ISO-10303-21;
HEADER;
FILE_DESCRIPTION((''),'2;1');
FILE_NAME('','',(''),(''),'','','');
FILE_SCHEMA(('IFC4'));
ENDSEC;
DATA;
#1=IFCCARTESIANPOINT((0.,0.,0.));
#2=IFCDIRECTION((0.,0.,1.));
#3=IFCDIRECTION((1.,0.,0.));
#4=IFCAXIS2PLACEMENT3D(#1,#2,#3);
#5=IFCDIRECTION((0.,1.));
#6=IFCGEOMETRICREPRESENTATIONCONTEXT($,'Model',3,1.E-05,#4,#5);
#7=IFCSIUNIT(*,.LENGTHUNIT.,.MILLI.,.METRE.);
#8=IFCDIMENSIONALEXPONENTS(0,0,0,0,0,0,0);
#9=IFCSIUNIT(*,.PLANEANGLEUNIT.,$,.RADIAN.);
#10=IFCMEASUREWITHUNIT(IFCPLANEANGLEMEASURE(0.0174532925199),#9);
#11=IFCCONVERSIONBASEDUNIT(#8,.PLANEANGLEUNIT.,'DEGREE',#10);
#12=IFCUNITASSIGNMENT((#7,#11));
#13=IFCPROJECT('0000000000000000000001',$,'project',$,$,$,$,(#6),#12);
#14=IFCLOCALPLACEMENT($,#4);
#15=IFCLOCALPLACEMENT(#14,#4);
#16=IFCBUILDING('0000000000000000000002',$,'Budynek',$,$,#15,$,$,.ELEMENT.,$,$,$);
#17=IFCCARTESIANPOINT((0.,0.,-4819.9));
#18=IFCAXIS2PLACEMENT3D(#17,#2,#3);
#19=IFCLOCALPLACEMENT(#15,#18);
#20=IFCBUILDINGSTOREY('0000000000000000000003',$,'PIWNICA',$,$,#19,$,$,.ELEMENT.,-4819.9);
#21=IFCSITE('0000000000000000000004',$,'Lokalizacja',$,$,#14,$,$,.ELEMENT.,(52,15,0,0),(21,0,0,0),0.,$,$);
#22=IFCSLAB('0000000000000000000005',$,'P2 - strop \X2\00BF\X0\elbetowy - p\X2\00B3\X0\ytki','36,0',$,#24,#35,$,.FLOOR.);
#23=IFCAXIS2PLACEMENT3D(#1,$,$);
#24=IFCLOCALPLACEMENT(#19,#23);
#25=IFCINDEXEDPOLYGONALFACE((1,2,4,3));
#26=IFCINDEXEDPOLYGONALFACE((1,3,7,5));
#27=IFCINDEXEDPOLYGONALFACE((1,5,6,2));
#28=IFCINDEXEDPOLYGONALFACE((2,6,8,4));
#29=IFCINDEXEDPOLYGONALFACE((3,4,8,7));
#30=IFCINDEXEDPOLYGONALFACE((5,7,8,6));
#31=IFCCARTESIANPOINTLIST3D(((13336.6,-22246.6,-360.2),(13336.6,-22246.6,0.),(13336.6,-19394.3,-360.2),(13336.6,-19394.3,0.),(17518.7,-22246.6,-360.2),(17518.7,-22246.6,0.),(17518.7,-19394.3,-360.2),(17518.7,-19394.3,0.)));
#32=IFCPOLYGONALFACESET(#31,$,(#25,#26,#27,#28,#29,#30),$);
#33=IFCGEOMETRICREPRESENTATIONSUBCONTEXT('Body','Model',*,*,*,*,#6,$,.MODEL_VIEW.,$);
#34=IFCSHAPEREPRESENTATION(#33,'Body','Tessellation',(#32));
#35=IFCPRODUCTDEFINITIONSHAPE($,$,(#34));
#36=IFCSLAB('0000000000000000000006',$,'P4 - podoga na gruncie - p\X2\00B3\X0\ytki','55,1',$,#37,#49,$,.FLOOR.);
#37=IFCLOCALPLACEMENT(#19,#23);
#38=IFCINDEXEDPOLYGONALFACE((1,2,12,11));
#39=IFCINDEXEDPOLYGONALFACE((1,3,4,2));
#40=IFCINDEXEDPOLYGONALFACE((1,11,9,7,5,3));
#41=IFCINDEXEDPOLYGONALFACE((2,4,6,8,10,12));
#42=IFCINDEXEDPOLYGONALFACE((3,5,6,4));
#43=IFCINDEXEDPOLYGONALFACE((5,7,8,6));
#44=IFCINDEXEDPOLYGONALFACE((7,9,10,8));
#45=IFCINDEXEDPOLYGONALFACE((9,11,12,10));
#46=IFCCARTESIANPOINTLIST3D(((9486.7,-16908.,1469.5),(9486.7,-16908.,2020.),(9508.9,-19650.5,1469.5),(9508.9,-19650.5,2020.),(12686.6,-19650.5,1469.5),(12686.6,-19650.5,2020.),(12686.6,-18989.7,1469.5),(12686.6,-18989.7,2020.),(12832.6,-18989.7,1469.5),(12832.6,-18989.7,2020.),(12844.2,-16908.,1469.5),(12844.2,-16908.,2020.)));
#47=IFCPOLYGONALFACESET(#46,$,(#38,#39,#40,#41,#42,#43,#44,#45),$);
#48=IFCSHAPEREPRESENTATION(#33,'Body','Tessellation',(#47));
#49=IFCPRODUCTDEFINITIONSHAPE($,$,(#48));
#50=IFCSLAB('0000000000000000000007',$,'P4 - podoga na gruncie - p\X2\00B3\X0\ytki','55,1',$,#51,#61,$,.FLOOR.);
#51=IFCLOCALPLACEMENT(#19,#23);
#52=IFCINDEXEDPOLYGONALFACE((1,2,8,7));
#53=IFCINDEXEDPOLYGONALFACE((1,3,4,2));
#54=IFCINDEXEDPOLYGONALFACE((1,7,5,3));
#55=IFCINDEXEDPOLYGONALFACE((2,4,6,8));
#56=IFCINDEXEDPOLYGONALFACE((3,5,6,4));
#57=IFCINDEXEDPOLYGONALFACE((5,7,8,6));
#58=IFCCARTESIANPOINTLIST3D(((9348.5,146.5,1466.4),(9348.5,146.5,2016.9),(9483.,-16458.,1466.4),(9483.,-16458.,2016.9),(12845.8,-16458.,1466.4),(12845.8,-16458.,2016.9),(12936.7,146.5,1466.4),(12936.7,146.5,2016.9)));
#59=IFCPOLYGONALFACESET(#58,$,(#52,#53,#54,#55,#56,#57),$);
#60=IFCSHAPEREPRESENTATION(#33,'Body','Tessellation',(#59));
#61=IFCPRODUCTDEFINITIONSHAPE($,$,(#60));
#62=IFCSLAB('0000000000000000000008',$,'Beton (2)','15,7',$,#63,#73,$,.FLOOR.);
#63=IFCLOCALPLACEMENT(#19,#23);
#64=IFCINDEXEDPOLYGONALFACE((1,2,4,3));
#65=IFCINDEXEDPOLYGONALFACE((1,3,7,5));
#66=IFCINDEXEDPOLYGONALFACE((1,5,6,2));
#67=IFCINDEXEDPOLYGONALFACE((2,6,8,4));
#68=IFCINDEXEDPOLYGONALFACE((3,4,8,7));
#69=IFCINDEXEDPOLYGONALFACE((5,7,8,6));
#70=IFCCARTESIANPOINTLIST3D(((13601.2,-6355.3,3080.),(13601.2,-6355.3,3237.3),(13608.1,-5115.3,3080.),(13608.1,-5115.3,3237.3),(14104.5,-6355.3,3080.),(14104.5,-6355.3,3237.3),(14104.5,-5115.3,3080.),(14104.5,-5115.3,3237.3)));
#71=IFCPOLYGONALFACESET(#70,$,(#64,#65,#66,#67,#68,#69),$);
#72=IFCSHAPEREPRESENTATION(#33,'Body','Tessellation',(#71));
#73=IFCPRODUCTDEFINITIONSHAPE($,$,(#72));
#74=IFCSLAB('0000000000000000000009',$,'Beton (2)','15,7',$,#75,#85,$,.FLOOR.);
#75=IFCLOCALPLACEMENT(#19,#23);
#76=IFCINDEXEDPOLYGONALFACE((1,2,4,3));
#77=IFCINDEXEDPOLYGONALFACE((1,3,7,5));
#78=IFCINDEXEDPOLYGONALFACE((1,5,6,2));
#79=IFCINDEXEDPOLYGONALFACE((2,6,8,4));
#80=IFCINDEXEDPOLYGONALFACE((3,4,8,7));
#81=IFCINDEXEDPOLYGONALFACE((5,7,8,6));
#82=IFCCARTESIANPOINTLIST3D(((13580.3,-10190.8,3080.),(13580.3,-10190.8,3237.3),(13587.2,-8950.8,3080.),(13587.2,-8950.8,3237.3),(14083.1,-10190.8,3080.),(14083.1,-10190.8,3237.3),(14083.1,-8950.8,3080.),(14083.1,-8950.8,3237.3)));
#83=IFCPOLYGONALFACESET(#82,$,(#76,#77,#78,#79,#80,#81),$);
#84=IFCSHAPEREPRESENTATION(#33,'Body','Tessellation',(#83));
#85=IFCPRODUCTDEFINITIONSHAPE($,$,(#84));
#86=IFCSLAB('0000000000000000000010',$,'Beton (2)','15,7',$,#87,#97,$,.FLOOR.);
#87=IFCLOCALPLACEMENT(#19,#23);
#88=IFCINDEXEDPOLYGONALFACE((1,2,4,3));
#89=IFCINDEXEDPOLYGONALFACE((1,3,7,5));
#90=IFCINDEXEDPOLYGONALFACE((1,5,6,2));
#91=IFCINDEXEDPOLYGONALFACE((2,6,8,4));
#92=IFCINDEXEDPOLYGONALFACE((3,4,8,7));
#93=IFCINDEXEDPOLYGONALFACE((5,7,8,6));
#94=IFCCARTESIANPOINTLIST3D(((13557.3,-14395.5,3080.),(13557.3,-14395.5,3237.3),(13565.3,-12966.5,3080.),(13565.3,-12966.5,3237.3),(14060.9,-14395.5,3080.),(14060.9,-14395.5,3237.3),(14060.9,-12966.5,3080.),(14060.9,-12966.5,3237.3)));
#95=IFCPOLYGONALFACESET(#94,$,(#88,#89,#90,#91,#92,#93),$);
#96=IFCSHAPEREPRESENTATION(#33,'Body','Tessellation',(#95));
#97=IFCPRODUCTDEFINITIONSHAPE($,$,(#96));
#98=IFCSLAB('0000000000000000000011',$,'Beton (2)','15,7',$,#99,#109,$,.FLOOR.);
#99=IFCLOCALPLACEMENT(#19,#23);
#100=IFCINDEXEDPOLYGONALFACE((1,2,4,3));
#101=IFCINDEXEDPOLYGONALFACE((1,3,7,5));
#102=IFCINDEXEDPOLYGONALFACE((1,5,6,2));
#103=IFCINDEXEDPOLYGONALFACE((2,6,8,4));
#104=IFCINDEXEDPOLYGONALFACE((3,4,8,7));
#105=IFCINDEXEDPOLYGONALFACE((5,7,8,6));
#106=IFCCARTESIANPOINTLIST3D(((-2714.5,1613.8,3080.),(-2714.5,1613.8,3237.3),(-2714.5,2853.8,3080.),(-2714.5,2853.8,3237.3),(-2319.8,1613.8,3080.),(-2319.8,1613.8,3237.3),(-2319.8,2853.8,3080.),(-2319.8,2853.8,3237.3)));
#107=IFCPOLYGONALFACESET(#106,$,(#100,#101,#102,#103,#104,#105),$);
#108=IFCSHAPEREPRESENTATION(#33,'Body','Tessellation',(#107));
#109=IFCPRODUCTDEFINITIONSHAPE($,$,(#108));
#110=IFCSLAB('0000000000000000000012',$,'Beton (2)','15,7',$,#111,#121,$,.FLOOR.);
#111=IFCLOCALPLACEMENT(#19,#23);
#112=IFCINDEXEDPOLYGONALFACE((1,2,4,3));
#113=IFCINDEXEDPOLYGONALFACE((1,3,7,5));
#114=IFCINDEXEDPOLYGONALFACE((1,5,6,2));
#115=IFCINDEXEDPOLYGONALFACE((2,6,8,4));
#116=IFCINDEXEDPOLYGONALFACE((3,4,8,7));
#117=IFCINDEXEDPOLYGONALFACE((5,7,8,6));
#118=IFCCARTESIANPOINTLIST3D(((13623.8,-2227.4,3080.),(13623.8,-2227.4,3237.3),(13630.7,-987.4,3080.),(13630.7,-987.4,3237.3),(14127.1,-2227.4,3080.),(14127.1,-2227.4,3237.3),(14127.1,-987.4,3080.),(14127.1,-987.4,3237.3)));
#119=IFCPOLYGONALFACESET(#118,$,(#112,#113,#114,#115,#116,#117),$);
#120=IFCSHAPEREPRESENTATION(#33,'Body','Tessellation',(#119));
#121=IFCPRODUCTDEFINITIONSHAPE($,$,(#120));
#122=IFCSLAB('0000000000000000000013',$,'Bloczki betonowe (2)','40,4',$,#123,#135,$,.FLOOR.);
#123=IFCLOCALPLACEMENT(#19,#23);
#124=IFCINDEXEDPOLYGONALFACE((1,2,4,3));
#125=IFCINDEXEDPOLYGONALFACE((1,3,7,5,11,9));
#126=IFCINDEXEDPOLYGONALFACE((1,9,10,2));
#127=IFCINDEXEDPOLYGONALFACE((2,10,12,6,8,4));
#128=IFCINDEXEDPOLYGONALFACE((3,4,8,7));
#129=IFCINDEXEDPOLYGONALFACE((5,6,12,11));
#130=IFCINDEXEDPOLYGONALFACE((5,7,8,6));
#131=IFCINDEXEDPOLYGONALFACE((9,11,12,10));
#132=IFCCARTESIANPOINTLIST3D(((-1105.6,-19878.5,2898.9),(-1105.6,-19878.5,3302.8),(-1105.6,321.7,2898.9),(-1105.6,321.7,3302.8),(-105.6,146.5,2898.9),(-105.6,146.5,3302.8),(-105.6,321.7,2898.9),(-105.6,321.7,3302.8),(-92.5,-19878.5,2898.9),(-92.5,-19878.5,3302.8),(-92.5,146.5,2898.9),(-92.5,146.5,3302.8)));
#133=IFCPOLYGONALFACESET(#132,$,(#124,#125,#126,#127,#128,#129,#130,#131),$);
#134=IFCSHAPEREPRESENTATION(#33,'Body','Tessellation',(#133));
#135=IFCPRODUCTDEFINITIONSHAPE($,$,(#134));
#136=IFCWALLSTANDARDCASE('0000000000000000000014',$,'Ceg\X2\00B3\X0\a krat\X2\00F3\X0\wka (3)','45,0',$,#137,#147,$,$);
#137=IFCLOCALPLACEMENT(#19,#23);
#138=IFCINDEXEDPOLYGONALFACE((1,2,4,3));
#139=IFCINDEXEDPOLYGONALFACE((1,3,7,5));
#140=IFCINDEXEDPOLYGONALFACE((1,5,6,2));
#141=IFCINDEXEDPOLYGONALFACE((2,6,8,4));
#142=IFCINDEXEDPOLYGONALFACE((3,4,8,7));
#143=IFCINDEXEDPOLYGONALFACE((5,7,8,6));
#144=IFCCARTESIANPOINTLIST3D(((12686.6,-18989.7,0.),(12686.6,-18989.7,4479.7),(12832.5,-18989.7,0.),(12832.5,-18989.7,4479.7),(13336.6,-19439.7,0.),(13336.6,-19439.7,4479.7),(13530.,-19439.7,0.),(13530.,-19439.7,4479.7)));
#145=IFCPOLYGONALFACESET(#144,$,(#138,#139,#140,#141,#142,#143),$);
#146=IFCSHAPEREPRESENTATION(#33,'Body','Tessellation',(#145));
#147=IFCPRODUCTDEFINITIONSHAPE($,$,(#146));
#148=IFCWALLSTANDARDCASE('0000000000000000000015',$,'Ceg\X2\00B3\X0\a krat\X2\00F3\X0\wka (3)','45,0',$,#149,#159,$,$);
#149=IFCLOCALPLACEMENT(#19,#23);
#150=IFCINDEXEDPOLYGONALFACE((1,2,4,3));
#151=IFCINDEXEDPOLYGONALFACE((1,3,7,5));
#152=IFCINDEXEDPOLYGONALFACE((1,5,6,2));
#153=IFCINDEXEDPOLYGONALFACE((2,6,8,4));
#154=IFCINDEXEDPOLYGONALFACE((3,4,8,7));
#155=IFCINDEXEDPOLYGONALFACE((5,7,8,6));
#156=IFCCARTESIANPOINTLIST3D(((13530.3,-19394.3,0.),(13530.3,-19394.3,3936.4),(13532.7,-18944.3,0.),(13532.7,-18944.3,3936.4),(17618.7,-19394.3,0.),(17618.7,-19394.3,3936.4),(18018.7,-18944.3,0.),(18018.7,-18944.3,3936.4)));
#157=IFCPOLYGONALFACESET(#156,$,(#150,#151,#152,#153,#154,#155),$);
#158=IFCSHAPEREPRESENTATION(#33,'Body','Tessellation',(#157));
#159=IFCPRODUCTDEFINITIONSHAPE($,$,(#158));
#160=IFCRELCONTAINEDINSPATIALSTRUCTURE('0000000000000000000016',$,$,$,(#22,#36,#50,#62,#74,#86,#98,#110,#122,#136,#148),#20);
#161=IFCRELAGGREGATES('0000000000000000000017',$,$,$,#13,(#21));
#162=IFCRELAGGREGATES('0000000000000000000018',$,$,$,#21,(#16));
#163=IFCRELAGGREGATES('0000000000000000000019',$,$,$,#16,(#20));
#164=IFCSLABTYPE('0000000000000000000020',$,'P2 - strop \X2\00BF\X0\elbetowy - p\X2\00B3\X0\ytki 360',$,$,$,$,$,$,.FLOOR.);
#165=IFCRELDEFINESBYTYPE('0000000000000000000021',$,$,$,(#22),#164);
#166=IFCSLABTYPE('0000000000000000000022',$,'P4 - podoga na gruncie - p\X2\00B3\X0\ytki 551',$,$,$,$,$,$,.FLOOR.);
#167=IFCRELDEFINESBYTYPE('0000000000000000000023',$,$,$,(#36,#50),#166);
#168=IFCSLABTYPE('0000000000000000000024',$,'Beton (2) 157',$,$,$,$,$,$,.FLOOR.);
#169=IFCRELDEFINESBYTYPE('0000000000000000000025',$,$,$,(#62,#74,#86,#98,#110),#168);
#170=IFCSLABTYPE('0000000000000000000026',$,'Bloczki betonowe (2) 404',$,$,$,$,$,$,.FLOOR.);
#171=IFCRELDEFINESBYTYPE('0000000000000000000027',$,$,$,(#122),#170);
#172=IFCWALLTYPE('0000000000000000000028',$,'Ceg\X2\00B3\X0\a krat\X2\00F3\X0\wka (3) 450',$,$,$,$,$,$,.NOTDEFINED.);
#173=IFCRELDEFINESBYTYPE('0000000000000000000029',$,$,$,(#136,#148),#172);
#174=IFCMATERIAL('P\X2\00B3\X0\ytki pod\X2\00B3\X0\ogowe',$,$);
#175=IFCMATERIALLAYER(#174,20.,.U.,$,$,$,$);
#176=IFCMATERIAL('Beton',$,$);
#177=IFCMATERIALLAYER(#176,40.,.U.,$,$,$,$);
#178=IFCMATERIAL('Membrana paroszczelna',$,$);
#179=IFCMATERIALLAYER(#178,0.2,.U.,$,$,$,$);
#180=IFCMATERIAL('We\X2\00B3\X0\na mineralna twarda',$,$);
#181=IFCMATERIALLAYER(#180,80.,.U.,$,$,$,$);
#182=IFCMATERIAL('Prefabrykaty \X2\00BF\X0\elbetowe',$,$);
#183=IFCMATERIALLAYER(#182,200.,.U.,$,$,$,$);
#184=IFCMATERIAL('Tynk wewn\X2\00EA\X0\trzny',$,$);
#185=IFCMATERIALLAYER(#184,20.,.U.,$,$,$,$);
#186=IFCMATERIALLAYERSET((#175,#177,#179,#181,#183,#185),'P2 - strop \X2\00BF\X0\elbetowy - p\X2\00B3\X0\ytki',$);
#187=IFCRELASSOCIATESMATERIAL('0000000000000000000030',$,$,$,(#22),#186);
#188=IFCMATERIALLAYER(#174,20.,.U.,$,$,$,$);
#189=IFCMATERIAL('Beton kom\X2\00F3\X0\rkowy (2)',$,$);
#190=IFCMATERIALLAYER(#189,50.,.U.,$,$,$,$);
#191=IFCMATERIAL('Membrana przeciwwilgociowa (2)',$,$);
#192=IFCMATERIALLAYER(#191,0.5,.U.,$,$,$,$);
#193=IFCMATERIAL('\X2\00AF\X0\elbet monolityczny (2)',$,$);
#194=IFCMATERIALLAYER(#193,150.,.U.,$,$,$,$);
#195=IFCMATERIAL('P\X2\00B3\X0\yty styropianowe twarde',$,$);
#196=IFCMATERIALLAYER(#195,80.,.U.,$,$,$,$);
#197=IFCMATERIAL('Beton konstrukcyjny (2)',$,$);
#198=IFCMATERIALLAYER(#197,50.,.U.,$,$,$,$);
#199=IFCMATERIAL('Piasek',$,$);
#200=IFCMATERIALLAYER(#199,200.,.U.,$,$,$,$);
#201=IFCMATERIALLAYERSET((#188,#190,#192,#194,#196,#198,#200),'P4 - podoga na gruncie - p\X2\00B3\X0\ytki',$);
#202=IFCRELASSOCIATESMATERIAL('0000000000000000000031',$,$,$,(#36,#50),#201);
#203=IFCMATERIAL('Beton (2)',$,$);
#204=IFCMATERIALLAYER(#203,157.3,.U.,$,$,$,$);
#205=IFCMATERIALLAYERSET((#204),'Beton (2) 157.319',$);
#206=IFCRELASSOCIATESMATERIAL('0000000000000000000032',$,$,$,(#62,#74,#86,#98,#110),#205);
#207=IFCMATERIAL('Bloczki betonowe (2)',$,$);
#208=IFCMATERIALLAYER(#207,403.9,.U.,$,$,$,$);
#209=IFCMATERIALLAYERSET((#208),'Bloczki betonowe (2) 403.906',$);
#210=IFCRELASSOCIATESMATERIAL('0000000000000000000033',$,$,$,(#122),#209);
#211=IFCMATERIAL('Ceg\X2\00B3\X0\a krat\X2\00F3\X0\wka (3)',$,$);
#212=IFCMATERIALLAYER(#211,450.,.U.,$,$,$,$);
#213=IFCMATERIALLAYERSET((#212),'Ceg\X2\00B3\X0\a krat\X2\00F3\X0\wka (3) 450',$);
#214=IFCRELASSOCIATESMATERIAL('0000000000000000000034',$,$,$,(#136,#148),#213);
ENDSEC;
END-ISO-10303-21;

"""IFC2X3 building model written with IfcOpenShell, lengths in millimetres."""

from ifc_helpers import new_model, entity, si_unit, converted_unit, direction, frame, origin_with_axes, place, context, subcontext, project, spatial, polyline, outline, extrude, material, layer, layer_set, layer_usage, type_object, element, save


model = new_model("IFC2X3")

# Units and contexts
model_context = context("Model", 3, precision=1e-05, world=origin_with_axes(), true_north=direction((0.0, 1.0)))
body_context = subcontext(model_context, "Body", "Model", "MODEL_VIEW")
ifc_project = project(units=[si_unit("LENGTHUNIT", "METRE", prefix="MILLI"), converted_unit("PLANEANGLEUNIT", "DEGREE", entity("IfcPlaneAngleMeasure", 0.0174532925199), si_unit("PLANEANGLEUNIT", "RADIAN"), dimensions=[0, 0, 0, 0, 0, 0, 0])], contexts=[model_context])

# Site, building, storey
site_placement = place(None, origin_with_axes())
site = spatial("IfcSite", under=ifc_project, at=site_placement, Name="Lokalizacja", CompositionType="ELEMENT", RefLatitude=(52, 15, 0, 0), RefLongitude=(21, 0, 0, 0), RefElevation=0.0)
building_placement = place(site_placement, origin_with_axes())
building = spatial("IfcBuilding", under=site, at=building_placement, Name="Budynek", CompositionType="ELEMENT")
storey_placement = place(building_placement, frame((0.0, 0.0, -4819.9), z_axis=(0.0, 0.0, 1.0), x_axis=(1.0, 0.0, 0.0)))
storey = spatial("IfcBuildingStorey", under=building, at=storey_placement, Name="PIWNICA", CompositionType="ELEMENT", Elevation=-4819.9)

# Slabs
ifc_material_1 = material(Name="P³ytki pod³ogowe")
ifc_layer_1 = layer(ifc_material_1, 20.0, ventilated="UNKNOWN")
ifc_material_2 = material(Name="Beton")
ifc_layer_2 = layer(ifc_material_2, 40.0, ventilated="UNKNOWN")
ifc_material_3 = material(Name="Membrana paroszczelna")
ifc_layer_3 = layer(ifc_material_3, 0.2, ventilated="UNKNOWN")
ifc_material_4 = material(Name="We³na mineralna twarda")
ifc_layer_4 = layer(ifc_material_4, 80.0, ventilated="UNKNOWN")
ifc_material_5 = material(Name="Prefabrykaty ¿elbetowe")
ifc_layer_5 = layer(ifc_material_5, 200.0, ventilated="UNKNOWN")
ifc_material_6 = material(Name="Tynk wewnêtrzny")
ifc_layer_6 = layer(ifc_material_6, 20.0, ventilated="UNKNOWN")
ifc_layer_set_1 = layer_set([ifc_layer_1, ifc_layer_2, ifc_layer_3, ifc_layer_4, ifc_layer_5, ifc_layer_6], Name="P2 - strop ¿elbetowy - p³ytki")
ifc_layer_usage_1 = layer_usage(ifc_layer_set_1, "AXIS3", "NEGATIVE", 360.2)
slab_type_1 = type_object("IfcSlabType", Name="P2 - strop ¿elbetowy - p³ytki 360", PredefinedType="FLOOR")
slab_1_placement = place(storey_placement, frame((13336.6, -19394.3, 0.0), z_axis=(0.0, 0.0, 1.0), x_axis=(1.0, 0.0, 0.0)))
element("IfcSlab", 1, at=slab_1_placement, inside=storey, type_object=slab_type_1, material=ifc_layer_usage_1, Name="P2 - strop ¿elbetowy - p³ytki", Description="36,0", PredefinedType="FLOOR", context=body_context, shape_type="SweptSolid", body=[
    extrude(outline(polyline([(0.0, 0.0), (0.0, -2852.3), (4182.1, -2852.3), (4182.1, 0.0), (0.0, 0.0)])), frame((0.0, 0.0, -360.2), z_axis=(0.0, 0.0, 1.0), x_axis=(1.0, 0.0, 0.0)), (0.0, 0.0, 1.0), 360.2),
])
ifc_layer_7 = layer(ifc_material_1, 20.0, ventilated="UNKNOWN")
ifc_material_7 = material(Name="Beton komórkowy (2)")
ifc_layer_8 = layer(ifc_material_7, 50.0, ventilated="UNKNOWN")
ifc_material_8 = material(Name="Membrana przeciwwilgociowa (2)")
ifc_layer_9 = layer(ifc_material_8, 0.5, ventilated="UNKNOWN")
ifc_material_9 = material(Name="¯elbet monolityczny (2)")
ifc_layer_10 = layer(ifc_material_9, 150.0, ventilated="UNKNOWN")
ifc_material_10 = material(Name="P³yty styropianowe twarde")
ifc_layer_11 = layer(ifc_material_10, 80.0, ventilated="UNKNOWN")
ifc_material_11 = material(Name="Beton konstrukcyjny (2)")
ifc_layer_12 = layer(ifc_material_11, 50.0, ventilated="UNKNOWN")
ifc_material_12 = material(Name="Piasek")
ifc_layer_13 = layer(ifc_material_12, 200.0, ventilated="UNKNOWN")
ifc_layer_set_2 = layer_set([ifc_layer_7, ifc_layer_8, ifc_layer_9, ifc_layer_10, ifc_layer_11, ifc_layer_12, ifc_layer_13], Name="P4 - podoga na gruncie - p³ytki")
ifc_layer_usage_2 = layer_usage(ifc_layer_set_2, "AXIS3", "NEGATIVE", 550.5)
slab_type_2 = type_object("IfcSlabType", Name="P4 - podoga na gruncie - p³ytki 551", PredefinedType="FLOOR")
slab_2_placement = place(storey_placement, frame((9486.7, -16908.0, 2020.0), z_axis=(0.0, 0.0, 1.0), x_axis=(1.0, 0.0, 0.0)))
element("IfcSlab", 2, at=slab_2_placement, inside=storey, type_object=slab_type_2, material=ifc_layer_usage_2, Name="P4 - podoga na gruncie - p³ytki", Description="55,1", PredefinedType="FLOOR", context=body_context, shape_type="SweptSolid", body=[
    extrude(outline(polyline([(0.0, 0.0), (22.2, -2742.4), (3199.9, -2742.4), (3199.9, -2081.7), (3345.9, -2081.7), (3357.5, 0.0), (0.0, 0.0)])), frame((0.0, 0.0, -550.5), z_axis=(0.0, 0.0, 1.0), x_axis=(1.0, 0.0, 0.0)), (0.0, 0.0, 1.0), 550.5),
])
ifc_layer_usage_3 = layer_usage(ifc_layer_set_2, "AXIS3", "NEGATIVE", 550.5)
slab_3_placement = place(storey_placement, frame((9348.5, 146.5, 2016.9), z_axis=(0.0, 0.0, 1.0), x_axis=(1.0, 0.0, 0.0)))
element("IfcSlab", 3, at=slab_3_placement, inside=storey, type_object=slab_type_2, material=ifc_layer_usage_3, Name="P4 - podoga na gruncie - p³ytki", Description="55,1", PredefinedType="FLOOR", context=body_context, shape_type="SweptSolid", body=[
    extrude(outline(polyline([(0.0, 0.0), (134.6, -16604.5), (3497.3, -16604.5), (3588.2, 0.0), (0.0, 0.0)])), frame((0.0, 0.0, -550.5), z_axis=(0.0, 0.0, 1.0), x_axis=(1.0, 0.0, 0.0)), (0.0, 0.0, 1.0), 550.5),
])
ifc_material_13 = material(Name="Beton (2)")
ifc_layer_14 = layer(ifc_material_13, 157.3, ventilated="UNKNOWN")
ifc_layer_set_3 = layer_set([ifc_layer_14], Name="Beton (2) 157.319")
ifc_layer_usage_4 = layer_usage(ifc_layer_set_3, "AXIS3", "NEGATIVE", 157.3)
slab_type_3 = type_object("IfcSlabType", Name="Beton (2) 157", PredefinedType="FLOOR")
slab_4_placement = place(storey_placement, frame((13608.1, -5115.3, 3237.3), z_axis=(0.0, 0.0, 1.0), x_axis=(1.0, 0.0, 0.0)))
element("IfcSlab", 4, at=slab_4_placement, inside=storey, type_object=slab_type_3, material=ifc_layer_usage_4, Name="Beton (2)", Description="15,7", PredefinedType="FLOOR", context=body_context, shape_type="SweptSolid", body=[
    extrude(outline(polyline([(0.0, 0.0), (-6.9, -1240.0), (496.4, -1240.0), (496.4, 0.0), (0.0, 0.0)])), frame((0.0, 0.0, -157.3), z_axis=(0.0, 0.0, 1.0), x_axis=(1.0, 0.0, 0.0)), (0.0, 0.0, 1.0), 157.3),
])
ifc_layer_usage_5 = layer_usage(ifc_layer_set_3, "AXIS3", "NEGATIVE", 157.3)
slab_5_placement = place(storey_placement, frame((13587.2, -8950.8, 3237.3), z_axis=(0.0, 0.0, 1.0), x_axis=(1.0, 0.0, 0.0)))
element("IfcSlab", 5, at=slab_5_placement, inside=storey, type_object=slab_type_3, material=ifc_layer_usage_5, Name="Beton (2)", Description="15,7", PredefinedType="FLOOR", context=body_context, shape_type="SweptSolid", body=[
    extrude(outline(polyline([(0.0, 0.0), (-6.9, -1240.0), (496.0, -1240.0), (496.0, 0.0), (0.0, 0.0)])), frame((0.0, 0.0, -157.3), z_axis=(0.0, 0.0, 1.0), x_axis=(1.0, 0.0, 0.0)), (0.0, 0.0, 1.0), 157.3),
])
ifc_layer_usage_6 = layer_usage(ifc_layer_set_3, "AXIS3", "NEGATIVE", 157.3)
slab_6_placement = place(storey_placement, frame((13565.3, -12966.5, 3237.3), z_axis=(0.0, 0.0, 1.0), x_axis=(1.0, 0.0, 0.0)))
element("IfcSlab", 6, at=slab_6_placement, inside=storey, type_object=slab_type_3, material=ifc_layer_usage_6, Name="Beton (2)", Description="15,7", PredefinedType="FLOOR", context=body_context, shape_type="SweptSolid", body=[
    extrude(outline(polyline([(0.0, 0.0), (-8.0, -1429.0), (495.6, -1429.0), (495.6, 0.0), (0.0, 0.0)])), frame((0.0, 0.0, -157.3), z_axis=(0.0, 0.0, 1.0), x_axis=(1.0, 0.0, 0.0)), (0.0, 0.0, 1.0), 157.3),
])
ifc_layer_usage_7 = layer_usage(ifc_layer_set_3, "AXIS3", "NEGATIVE", 157.3)
slab_7_placement = place(storey_placement, frame((-2319.8, 2853.8, 3237.3), z_axis=(0.0, 0.0, 1.0), x_axis=(1.0, 0.0, 0.0)))
element("IfcSlab", 7, at=slab_7_placement, inside=storey, type_object=slab_type_3, material=ifc_layer_usage_7, Name="Beton (2)", Description="15,7", PredefinedType="FLOOR", context=body_context, shape_type="SweptSolid", body=[
    extrude(outline(polyline([(0.0, 0.0), (-394.6, 0.0), (-394.6, -1240.0), (0.0, -1240.0), (0.0, 0.0)])), frame((0.0, 0.0, -157.3), z_axis=(0.0, 0.0, 1.0), x_axis=(1.0, 0.0, 0.0)), (0.0, 0.0, 1.0), 157.3),
])
ifc_layer_usage_8 = layer_usage(ifc_layer_set_3, "AXIS3", "NEGATIVE", 157.3)
slab_8_placement = place(storey_placement, frame((13630.7, -987.4, 3237.3), z_axis=(0.0, 0.0, 1.0), x_axis=(1.0, 0.0, 0.0)))
element("IfcSlab", 8, at=slab_8_placement, inside=storey, type_object=slab_type_3, material=ifc_layer_usage_8, Name="Beton (2)", Description="15,7", PredefinedType="FLOOR", context=body_context, shape_type="SweptSolid", body=[
    extrude(outline(polyline([(0.0, 0.0), (-6.9, -1240.0), (496.4, -1240.0), (496.4, 0.0), (0.0, 0.0)])), frame((0.0, 0.0, -157.3), z_axis=(0.0, 0.0, 1.0), x_axis=(1.0, 0.0, 0.0)), (0.0, 0.0, 1.0), 157.3),
])
ifc_material_14 = material(Name="Bloczki betonowe (2)")
ifc_layer_15 = layer(ifc_material_14, 403.9, ventilated="UNKNOWN")
ifc_layer_set_4 = layer_set([ifc_layer_15], Name="Bloczki betonowe (2) 403.906")
ifc_layer_usage_9 = layer_usage(ifc_layer_set_4, "AXIS3", "NEGATIVE", 403.9)
slab_type_4 = type_object("IfcSlabType", Name="Bloczki betonowe (2) 404", PredefinedType="FLOOR")
slab_9_placement = place(storey_placement, frame((-1105.6, 321.7, 3302.8), z_axis=(0.0, 0.0, 1.0), x_axis=(1.0, 0.0, 0.0)))
element("IfcSlab", 9, at=slab_9_placement, inside=storey, type_object=slab_type_4, material=ifc_layer_usage_9, Name="Bloczki betonowe (2)", Description="40,4", PredefinedType="FLOOR", context=body_context, shape_type="SweptSolid", body=[
    extrude(outline(polyline([(0.0, 0.0), (0.0, -20200.2), (1013.1, -20200.2), (1013.1, -175.2), (1000.0, -175.2), (1000.0, 0.0), (0.0, 0.0)])), frame((0.0, 0.0, -403.9), z_axis=(0.0, 0.0, 1.0), x_axis=(1.0, 0.0, 0.0)), (0.0, 0.0, 1.0), 403.9),
])

# Wall
ifc_material_15 = material(Name="Ceg³a kratówka (3)")
ifc_layer_16 = layer(ifc_material_15, 450.0, ventilated="UNKNOWN")
ifc_layer_set_5 = layer_set([ifc_layer_16], Name="Ceg³a kratówka (3) 450")
ifc_layer_usage_10 = layer_usage(ifc_layer_set_5, "AXIS2", "POSITIVE", 0.0)
wall_type_1 = type_object("IfcWallType", Name="Ceg³a kratówka (3) 450", PredefinedType="NOTDEFINED")
wall_1_placement = place(storey_placement, frame((12686.6, -19439.7, 0.0), z_axis=(0.0, 0.0, 1.0), x_axis=(1.0, 0.0, 0.0)))
element("IfcWallStandardCase", 10, at=wall_1_placement, inside=storey, type_object=wall_type_1, material=ifc_layer_usage_10, Name="Ceg³a kratówka (3)", Description="45,0", context=body_context, shape_type="SweptSolid", body=[
    extrude(outline(polyline([(650.0, 0.0), (843.4, 0.0), (145.9, 450.0), (0.0, 450.0), (650.0, 0.0)])), origin_with_axes(), (0.0, 0.0, 1.0), 4479.7),
])

# Wall
ifc_layer_usage_11 = layer_usage(ifc_layer_set_5, "AXIS2", "POSITIVE", 0.0)
wall_2_placement = place(storey_placement, frame((13530.3, -19394.3, 0.0), z_axis=(0.0, 0.0, 1.0), x_axis=(1.0, 0.0, 0.0)))
element("IfcWallStandardCase", 11, at=wall_2_placement, inside=storey, type_object=wall_type_1, material=ifc_layer_usage_11, Name="Ceg³a kratówka (3)", Description="45,0", context=body_context, shape_type="SweptSolid", body=[
    extrude(outline(polyline([(0.0, 0.0), (4088.4, 0.0), (4488.4, 450.0), (2.5, 450.0), (0.0, 0.0)])), origin_with_axes(), (0.0, 0.0, 1.0), 3936.4),
])

save(model, "model.ifc")
